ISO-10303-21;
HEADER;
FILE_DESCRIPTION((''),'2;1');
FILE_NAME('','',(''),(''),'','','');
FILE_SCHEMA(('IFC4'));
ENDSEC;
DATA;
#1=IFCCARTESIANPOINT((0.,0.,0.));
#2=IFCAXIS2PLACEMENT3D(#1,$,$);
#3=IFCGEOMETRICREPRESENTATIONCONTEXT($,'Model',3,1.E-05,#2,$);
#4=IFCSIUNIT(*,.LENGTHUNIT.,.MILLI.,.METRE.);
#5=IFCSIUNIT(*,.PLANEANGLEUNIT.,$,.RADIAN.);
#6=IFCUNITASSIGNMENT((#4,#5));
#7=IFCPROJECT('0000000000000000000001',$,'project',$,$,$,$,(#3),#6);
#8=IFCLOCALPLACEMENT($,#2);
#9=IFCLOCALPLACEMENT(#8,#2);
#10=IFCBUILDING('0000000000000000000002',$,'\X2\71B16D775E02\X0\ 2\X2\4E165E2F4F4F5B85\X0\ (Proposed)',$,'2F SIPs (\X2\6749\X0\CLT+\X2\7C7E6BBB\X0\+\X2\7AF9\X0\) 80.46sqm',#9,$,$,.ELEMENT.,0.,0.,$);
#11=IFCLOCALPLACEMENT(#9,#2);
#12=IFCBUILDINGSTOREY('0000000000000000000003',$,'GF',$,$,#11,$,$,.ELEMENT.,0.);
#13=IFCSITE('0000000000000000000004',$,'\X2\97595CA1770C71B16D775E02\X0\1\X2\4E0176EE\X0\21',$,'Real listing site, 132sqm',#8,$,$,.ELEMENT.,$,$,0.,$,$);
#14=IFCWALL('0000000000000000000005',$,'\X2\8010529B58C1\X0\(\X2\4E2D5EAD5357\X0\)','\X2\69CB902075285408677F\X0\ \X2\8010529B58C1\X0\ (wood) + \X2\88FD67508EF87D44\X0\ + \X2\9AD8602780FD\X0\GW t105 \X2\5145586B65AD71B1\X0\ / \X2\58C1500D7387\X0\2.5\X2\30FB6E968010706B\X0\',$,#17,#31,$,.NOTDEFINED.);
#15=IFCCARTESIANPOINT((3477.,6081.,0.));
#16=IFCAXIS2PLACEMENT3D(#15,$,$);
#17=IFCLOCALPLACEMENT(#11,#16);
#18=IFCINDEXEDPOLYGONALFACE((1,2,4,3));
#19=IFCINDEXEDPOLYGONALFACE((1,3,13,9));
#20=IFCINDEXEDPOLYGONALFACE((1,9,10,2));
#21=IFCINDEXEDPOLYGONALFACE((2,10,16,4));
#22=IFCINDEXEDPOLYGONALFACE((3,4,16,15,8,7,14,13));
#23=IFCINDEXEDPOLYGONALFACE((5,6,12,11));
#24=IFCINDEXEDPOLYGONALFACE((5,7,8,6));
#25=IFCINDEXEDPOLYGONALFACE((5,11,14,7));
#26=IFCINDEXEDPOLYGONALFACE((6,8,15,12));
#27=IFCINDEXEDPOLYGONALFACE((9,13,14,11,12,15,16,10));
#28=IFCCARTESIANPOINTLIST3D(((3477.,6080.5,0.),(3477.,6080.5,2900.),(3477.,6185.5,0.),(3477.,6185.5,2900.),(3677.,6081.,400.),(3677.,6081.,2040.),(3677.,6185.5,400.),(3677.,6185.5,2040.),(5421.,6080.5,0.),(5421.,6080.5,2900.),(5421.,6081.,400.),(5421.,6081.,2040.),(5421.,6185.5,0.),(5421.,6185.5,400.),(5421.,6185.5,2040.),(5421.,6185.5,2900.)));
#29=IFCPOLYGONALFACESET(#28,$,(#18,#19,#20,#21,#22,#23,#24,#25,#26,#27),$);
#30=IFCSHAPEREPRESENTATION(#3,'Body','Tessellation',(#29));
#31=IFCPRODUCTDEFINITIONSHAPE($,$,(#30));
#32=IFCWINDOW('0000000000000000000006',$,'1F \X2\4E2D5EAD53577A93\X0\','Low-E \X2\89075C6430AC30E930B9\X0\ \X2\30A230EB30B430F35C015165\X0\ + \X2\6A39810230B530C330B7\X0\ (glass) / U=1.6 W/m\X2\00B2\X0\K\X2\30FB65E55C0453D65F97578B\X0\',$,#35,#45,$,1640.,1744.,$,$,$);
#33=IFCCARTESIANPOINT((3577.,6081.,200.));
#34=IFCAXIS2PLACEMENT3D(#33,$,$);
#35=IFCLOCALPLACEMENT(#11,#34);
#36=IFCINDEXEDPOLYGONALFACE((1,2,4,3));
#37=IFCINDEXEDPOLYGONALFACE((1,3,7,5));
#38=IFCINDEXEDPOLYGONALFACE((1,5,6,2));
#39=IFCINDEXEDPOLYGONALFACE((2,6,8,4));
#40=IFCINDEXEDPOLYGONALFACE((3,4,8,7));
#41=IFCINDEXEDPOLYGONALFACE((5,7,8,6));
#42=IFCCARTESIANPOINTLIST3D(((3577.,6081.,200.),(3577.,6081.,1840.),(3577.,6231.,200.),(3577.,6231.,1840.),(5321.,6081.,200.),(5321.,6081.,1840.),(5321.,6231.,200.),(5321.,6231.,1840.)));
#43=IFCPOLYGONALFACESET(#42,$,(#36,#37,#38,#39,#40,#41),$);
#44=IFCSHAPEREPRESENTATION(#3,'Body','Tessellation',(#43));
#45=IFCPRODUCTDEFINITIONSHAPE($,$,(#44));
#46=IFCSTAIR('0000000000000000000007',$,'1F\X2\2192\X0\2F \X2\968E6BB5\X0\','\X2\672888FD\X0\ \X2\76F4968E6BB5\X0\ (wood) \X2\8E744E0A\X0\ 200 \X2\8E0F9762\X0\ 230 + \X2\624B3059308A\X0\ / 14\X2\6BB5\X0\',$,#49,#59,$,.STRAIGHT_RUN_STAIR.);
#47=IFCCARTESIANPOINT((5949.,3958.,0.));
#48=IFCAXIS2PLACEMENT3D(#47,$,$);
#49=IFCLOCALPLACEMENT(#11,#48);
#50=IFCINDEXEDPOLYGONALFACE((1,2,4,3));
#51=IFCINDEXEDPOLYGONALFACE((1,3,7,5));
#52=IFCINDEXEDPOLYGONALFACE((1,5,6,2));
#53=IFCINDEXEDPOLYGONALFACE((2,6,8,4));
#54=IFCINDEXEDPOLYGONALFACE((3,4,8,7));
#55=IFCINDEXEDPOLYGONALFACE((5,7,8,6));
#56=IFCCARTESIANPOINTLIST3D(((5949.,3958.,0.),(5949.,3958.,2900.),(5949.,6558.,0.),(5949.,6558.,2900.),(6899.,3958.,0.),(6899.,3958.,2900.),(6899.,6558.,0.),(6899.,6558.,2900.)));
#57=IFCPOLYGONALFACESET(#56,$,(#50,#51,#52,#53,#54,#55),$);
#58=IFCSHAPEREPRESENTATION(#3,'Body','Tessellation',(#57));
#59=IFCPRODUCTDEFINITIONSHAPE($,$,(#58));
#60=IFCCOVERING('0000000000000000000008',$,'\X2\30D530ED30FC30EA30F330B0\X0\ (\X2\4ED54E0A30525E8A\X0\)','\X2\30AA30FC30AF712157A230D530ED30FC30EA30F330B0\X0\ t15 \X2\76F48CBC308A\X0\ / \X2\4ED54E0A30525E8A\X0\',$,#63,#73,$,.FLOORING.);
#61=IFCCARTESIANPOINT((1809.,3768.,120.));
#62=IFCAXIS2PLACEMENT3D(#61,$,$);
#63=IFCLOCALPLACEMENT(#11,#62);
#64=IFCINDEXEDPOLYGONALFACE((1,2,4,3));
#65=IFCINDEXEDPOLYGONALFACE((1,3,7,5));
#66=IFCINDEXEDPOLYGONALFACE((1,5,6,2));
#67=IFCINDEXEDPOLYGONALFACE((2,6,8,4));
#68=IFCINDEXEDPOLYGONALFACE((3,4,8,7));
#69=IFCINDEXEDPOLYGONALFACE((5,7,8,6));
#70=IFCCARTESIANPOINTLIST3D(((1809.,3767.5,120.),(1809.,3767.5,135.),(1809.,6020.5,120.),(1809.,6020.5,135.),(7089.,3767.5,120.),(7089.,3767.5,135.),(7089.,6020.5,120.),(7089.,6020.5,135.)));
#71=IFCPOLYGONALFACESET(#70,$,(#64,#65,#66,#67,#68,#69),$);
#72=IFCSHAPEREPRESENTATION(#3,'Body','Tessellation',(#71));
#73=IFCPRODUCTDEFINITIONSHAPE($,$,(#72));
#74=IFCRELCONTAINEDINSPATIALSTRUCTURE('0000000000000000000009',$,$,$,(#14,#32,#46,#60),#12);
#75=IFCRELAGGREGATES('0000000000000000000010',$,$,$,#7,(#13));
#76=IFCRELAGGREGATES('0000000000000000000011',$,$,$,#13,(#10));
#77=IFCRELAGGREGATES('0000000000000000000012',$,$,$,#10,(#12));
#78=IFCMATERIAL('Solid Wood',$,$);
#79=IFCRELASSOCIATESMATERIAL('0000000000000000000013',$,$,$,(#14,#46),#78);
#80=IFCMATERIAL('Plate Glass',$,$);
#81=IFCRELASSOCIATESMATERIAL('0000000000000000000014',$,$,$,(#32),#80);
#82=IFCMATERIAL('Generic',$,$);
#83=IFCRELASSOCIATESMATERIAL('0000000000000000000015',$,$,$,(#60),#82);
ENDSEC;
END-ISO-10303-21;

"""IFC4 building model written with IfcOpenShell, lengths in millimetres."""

from ifc_helpers import new_model, si_unit, frame, frame_2d, origin, place, context, project, spatial, rectangle, extrude, material, element, fill, save


model = new_model("IFC4")

# Units and contexts
model_context = context("Model", 3, precision=1e-05, world=origin())
ifc_project = project(units=[si_unit("LENGTHUNIT", "METRE", prefix="MILLI"), si_unit("PLANEANGLEUNIT", "RADIAN")], contexts=[model_context])

# Site, building, storey
site_placement = place(None, origin())
site = spatial("IfcSite", under=ifc_project, at=site_placement, Name="静岡県熱海市1丁目21", ObjectType="Real listing site, 132sqm", CompositionType="ELEMENT", RefElevation=0.0)
building_placement = place(site_placement, origin())
building = spatial("IfcBuilding", under=site, at=building_placement, Name="熱海市 2世帯住宅 (Proposed)", ObjectType="2F SIPs (杉CLT+籾殻+竹) 80.46sqm", CompositionType="ELEMENT", ElevationOfRefHeight=0.0, ElevationOfTerrain=0.0)
storey_placement = place(building_placement, origin())
storey = spatial("IfcBuildingStorey", under=building, at=storey_placement, Name="GF", CompositionType="ELEMENT", Elevation=0.0)

# Shared definitions
ifc_material_1 = material(Name="Solid Wood")
ifc_material_2 = material(Name="Generic")

# Shared definitions
ifc_material_3 = material(Name="Plate Glass")

# Wall, opening, window
wall_1_placement = place(storey_placement, frame((3477.0, 6081.0, 0.0)))
wall_1 = element("IfcWall", 1, at=wall_1_placement, inside=storey, material=ifc_material_1, Name="耐力壁(中庭南)", Description="構造用合板 耐力壁 (wood) + 製材軸組 + 高性能GW t105 充填断熱 / 壁倍率2.5・準耐火", PredefinedType="NOTDEFINED", context=model_context, shape_type="SweptSolid", body=[
    extrude(rectangle(XDim=1944.0, YDim=105.0, at=frame_2d((972.0, 52.0))), frame((3477.0, 6081.0, 0.0)), (0.0, 0.0, 1.0), 2900.0),
])
opening_1_placement = place(storey_placement, frame((3577.0, 6081.0, 200.0)))
opening_1 = element("IfcOpeningElement", 2, at=opening_1_placement, cuts=wall_1, PredefinedType="NOTDEFINED", context=model_context, shape_type="SweptSolid", body=[
    extrude(rectangle(XDim=1744.0, YDim=150.0, at=frame_2d((872.0, 75.0))), frame((3577.0, 6081.0, 200.0)), (0.0, 0.0, 1.0), 1640.0),
])
window_1_placement = place(storey_placement, frame((3577.0, 6081.0, 200.0)))
window_1 = element("IfcWindow", 3, at=window_1_placement, inside=storey, material=ifc_material_3, Name="1F 中庭南窓", Description="Low-E 複層ガラス アルゴン封入 + 樹脂サッシ (glass) / U=1.6 W/m²K・日射取得型", OverallHeight=1640.0, OverallWidth=1744.0, context=model_context, shape_type="SweptSolid", body=[
    extrude(rectangle(XDim=1744.0, YDim=150.0, at=frame_2d((872.0, 75.0))), frame((3577.0, 6081.0, 200.0)), (0.0, 0.0, 1.0), 1640.0),
])
fill(opening_1, window_1)

# Stair
stair_placement = place(storey_placement, frame((5949.0, 3958.0, 0.0)))
element("IfcStair", 4, at=stair_placement, inside=storey, material=ifc_material_1, Name="1F→2F 階段", Description="木製 直階段 (wood) 蹴上 200 踏面 230 + 手すり / 14段", PredefinedType="STRAIGHT_RUN_STAIR", context=model_context, shape_type="SweptSolid", body=[
    extrude(rectangle(XDim=950.0, YDim=2600.0, at=frame_2d((475.0, 1300.0))), frame((5949.0, 3958.0, 0.0)), (0.0, 0.0, 1.0), 2900.0),
])

# Covering
covering_placement = place(storey_placement, frame((1809.0, 3768.0, 120.0)))
element("IfcCovering", 5, at=covering_placement, inside=storey, material=ifc_material_2, Name="フローリング (仕上げ床)", Description="オーク無垢フローリング t15 直貼り / 仕上げ床", PredefinedType="FLOORING", context=model_context, shape_type="SweptSolid", body=[
    extrude(rectangle(XDim=5280.0, YDim=2253.0, at=frame_2d((2640.0, 1126.0))), frame((1809.0, 3768.0, 120.0)), (0.0, 0.0, 1.0), 15.0),
])

save(model, "model.ifc")
